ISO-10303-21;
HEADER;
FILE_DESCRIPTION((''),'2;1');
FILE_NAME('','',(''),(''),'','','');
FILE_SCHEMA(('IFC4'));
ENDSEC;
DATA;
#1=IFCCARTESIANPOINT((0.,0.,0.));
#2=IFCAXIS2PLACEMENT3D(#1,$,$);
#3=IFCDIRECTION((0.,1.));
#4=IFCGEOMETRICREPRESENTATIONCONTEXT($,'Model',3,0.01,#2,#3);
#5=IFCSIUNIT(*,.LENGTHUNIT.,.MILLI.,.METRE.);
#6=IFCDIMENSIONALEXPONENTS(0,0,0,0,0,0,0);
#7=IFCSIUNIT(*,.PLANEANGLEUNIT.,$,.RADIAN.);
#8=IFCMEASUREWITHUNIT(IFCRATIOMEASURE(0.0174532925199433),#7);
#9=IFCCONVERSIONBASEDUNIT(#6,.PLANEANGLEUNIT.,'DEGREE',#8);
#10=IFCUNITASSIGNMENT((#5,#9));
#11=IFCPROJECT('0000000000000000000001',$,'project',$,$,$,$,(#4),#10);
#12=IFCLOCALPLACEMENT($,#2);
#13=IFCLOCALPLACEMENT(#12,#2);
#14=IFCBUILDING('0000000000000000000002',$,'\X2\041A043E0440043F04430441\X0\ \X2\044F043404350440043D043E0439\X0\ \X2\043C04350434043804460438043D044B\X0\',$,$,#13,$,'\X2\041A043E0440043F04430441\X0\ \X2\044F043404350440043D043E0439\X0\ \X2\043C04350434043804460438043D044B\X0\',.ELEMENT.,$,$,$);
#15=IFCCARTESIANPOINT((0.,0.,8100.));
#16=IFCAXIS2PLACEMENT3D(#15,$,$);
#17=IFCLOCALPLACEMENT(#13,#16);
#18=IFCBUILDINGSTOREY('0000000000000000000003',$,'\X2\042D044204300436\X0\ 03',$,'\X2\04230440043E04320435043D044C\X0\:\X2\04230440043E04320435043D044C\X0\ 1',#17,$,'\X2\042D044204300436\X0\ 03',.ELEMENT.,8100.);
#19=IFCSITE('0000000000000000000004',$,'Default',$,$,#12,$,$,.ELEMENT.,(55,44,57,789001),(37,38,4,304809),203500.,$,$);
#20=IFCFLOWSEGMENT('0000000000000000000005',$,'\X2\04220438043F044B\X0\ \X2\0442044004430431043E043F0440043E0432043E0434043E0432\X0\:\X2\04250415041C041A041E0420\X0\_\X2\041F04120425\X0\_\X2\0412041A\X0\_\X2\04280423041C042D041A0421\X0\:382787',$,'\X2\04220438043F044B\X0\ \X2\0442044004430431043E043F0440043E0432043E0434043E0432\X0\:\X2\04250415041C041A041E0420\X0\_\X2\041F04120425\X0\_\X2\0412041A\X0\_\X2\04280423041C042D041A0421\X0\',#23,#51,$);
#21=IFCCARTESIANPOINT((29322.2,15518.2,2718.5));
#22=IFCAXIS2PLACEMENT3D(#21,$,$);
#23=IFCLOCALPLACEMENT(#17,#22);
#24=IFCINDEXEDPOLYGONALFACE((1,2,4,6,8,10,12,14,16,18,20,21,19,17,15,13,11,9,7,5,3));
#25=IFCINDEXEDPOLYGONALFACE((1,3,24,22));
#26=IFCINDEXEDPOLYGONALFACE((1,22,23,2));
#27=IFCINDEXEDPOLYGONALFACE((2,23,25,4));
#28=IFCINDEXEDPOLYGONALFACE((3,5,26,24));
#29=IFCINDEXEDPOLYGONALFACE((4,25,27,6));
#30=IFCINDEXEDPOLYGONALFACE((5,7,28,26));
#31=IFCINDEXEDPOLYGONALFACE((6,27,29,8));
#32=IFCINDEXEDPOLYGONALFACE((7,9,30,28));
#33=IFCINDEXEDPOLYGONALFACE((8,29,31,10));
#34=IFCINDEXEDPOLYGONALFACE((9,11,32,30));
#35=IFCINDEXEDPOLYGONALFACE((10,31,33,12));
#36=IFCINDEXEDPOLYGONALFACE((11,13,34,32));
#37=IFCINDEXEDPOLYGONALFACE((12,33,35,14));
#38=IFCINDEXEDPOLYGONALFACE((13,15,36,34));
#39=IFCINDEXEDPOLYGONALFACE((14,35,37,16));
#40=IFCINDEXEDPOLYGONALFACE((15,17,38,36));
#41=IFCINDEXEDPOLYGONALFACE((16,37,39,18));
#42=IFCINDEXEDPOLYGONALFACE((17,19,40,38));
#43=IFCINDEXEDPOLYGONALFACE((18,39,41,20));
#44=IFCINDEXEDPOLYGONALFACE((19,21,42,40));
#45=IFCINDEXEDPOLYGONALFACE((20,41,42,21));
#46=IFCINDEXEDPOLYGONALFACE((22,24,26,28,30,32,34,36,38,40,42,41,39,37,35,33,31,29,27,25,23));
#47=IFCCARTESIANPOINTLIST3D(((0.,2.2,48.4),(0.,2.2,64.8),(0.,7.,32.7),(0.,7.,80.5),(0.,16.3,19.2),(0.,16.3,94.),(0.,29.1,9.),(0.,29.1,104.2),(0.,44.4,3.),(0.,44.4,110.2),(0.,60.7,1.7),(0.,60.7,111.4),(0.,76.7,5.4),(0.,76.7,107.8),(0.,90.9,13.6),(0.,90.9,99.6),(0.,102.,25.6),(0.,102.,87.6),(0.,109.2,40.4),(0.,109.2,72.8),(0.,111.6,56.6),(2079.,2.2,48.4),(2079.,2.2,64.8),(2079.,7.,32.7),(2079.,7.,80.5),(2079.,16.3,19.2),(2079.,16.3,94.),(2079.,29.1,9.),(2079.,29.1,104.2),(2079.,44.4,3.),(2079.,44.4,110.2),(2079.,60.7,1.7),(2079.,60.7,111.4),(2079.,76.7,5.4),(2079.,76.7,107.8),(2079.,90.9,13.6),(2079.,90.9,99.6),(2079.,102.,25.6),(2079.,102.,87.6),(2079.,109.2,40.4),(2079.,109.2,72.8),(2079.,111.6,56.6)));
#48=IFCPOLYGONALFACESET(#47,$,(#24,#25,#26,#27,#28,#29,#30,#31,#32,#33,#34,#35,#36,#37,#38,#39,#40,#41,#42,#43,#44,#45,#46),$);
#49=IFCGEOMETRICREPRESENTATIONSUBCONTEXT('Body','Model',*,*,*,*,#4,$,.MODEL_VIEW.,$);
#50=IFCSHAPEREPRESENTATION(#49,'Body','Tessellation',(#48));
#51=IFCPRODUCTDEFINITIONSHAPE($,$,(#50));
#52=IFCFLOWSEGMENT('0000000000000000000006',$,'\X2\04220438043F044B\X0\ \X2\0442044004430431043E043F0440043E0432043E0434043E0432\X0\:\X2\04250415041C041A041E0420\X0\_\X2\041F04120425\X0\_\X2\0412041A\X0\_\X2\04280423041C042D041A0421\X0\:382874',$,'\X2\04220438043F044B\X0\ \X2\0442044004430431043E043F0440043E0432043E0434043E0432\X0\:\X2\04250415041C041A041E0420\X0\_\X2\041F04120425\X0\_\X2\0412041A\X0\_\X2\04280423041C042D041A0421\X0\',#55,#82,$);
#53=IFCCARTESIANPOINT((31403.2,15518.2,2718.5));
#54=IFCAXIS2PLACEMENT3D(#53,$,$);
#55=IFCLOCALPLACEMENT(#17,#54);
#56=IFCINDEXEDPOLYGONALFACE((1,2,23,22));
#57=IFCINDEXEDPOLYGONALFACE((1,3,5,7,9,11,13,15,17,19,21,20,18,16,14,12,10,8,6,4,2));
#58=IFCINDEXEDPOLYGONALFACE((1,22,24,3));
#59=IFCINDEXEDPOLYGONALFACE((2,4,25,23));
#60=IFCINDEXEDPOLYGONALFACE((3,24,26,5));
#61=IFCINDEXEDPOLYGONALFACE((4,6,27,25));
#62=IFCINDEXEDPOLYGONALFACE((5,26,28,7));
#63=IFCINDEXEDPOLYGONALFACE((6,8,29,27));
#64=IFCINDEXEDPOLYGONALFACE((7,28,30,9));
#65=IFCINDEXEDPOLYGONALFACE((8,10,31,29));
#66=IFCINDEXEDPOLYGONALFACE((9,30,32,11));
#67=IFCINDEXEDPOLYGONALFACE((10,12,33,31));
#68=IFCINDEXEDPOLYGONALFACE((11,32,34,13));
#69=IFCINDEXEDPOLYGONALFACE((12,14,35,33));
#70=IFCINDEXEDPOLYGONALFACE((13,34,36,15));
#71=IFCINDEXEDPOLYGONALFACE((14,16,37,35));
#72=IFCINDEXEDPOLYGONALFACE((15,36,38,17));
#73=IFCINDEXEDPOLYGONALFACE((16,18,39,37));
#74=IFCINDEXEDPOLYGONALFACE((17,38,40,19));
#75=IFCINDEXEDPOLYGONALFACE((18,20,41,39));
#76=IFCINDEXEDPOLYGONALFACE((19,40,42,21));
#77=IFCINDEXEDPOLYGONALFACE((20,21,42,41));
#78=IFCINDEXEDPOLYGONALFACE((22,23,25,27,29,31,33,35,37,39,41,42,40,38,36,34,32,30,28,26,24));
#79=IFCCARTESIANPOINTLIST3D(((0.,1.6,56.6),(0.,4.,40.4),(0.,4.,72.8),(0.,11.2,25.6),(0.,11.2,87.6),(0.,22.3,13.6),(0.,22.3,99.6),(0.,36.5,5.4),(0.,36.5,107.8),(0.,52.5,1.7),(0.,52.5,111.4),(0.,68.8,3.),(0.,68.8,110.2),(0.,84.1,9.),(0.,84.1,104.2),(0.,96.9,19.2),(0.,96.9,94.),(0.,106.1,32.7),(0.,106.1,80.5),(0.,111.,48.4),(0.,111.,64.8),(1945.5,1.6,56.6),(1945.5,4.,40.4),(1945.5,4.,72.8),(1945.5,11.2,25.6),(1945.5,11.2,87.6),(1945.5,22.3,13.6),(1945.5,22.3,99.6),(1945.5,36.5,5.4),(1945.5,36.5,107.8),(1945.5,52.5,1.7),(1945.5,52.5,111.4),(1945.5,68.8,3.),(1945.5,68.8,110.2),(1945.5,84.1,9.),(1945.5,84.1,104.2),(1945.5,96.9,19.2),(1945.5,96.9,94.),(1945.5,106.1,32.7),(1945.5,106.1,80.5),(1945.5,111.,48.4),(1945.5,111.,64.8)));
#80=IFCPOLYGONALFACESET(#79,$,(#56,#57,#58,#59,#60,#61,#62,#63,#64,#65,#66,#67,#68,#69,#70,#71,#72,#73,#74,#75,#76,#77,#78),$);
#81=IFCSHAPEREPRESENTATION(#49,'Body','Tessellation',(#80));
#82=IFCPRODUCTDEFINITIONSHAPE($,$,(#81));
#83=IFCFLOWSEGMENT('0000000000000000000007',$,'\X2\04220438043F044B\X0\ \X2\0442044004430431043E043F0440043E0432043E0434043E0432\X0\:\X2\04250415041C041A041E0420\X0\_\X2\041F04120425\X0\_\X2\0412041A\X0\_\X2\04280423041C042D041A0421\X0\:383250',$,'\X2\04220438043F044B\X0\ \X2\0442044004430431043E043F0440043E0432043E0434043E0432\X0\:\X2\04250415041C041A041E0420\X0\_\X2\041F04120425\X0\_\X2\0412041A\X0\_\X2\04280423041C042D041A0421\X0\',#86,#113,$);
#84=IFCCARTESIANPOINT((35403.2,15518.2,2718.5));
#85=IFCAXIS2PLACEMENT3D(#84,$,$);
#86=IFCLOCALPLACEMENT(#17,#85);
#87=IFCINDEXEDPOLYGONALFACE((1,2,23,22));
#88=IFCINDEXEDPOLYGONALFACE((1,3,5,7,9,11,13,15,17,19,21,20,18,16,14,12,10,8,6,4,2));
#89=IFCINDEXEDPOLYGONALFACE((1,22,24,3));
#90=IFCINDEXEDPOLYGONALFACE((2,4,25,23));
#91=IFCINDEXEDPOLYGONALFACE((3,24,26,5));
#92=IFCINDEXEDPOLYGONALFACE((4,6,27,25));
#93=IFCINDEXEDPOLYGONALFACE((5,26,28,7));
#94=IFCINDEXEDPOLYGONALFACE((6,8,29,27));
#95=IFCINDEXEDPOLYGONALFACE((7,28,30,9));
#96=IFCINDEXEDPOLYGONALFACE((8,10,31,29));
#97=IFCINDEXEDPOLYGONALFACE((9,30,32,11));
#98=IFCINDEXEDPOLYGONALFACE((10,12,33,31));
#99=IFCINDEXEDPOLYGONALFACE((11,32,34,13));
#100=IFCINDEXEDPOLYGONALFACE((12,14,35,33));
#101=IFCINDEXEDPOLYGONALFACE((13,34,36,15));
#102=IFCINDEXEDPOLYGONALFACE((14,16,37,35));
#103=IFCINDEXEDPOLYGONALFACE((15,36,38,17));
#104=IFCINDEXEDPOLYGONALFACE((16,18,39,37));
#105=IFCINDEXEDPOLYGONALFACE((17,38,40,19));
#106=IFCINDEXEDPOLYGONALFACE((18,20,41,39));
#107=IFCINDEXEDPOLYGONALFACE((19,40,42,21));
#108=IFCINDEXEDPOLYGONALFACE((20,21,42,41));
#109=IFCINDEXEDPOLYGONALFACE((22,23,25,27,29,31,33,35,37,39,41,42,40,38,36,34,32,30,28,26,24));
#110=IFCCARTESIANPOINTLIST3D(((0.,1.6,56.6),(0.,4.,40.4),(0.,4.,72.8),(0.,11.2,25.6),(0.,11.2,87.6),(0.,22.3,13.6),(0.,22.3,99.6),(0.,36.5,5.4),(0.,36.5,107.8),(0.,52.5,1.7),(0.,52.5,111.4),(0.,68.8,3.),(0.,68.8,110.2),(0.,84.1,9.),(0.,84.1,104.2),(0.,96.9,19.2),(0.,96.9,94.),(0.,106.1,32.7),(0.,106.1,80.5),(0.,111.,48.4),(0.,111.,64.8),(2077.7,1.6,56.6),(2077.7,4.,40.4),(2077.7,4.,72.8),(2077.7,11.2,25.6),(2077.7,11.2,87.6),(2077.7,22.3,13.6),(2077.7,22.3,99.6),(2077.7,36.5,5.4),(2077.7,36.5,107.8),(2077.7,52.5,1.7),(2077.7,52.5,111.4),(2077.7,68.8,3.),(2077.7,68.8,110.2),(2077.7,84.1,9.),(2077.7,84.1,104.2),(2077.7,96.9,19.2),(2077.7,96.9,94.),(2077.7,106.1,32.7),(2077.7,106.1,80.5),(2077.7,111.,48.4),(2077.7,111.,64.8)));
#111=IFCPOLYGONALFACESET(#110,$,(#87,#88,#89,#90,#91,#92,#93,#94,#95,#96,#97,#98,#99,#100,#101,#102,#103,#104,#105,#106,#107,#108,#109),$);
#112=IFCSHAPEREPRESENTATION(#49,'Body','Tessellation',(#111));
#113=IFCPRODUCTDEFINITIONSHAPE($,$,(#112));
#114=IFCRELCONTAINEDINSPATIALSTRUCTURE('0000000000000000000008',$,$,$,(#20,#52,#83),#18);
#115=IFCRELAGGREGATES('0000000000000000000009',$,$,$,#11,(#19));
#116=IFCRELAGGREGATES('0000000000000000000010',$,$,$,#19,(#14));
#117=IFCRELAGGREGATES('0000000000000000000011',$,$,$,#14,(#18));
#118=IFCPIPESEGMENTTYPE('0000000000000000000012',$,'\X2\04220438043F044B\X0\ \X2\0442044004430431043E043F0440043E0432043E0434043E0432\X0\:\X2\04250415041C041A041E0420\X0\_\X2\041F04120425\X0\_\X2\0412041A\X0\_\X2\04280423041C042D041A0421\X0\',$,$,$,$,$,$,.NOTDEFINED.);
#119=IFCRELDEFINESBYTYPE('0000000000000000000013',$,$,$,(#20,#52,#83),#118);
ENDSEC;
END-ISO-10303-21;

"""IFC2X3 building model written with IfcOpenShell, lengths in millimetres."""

from ifc_helpers import new_model, entity, si_unit, converted_unit, direction, frame, frame_2d, origin, origin_2d_with_axis, place, context, subcontext, project, spatial, circle, extrude, type_object, element, save


model = new_model("IFC2X3")

# Units and contexts
model_context = context("Model", 3, precision=0.01, world=origin(), true_north=direction((0.0, 1.0)))
body_context = subcontext(model_context, "Body", "Model", "MODEL_VIEW")
ifc_project = project(units=[si_unit("LENGTHUNIT", "METRE", prefix="MILLI"), converted_unit("PLANEANGLEUNIT", "DEGREE", entity("IfcRatioMeasure", 0.0174532925199433), si_unit("PLANEANGLEUNIT", "RADIAN"), dimensions=[0, 0, 0, 0, 0, 0, 0])], contexts=[model_context])

# Site, building, storey
site_placement = place(None, frame((0.0, 0.0, 0.0)))
site = spatial("IfcSite", under=ifc_project, at=site_placement, Name="Default", CompositionType="ELEMENT", RefLatitude=(55, 44, 57, 789001), RefLongitude=(37, 38, 4, 304809), RefElevation=203500.0)
building_placement = place(site_placement, origin())
building = spatial("IfcBuilding", under=site, at=building_placement, Name="Корпус ядерной медицины", LongName="Корпус ядерной медицины", CompositionType="ELEMENT")
storey_placement = place(building_placement, frame((0.0, 0.0, 8100.0)))
storey = spatial("IfcBuildingStorey", under=building, at=storey_placement, Name="Этаж 03", ObjectType="Уровень:Уровень 1", LongName="Этаж 03", CompositionType="ELEMENT", Elevation=8100.0)

# Flow segments
pipe_segment_type = type_object("IfcPipeSegmentType", Name="Типы трубопроводов:ХЕМКОР_ПВХ_ВК_ШУМЭКС", PredefinedType="NOTDEFINED")
flow_segment_1_placement = place(storey_placement, frame((29322.2, 15518.2, 2718.5)))
element("IfcFlowSegment", 1, at=flow_segment_1_placement, inside=storey, type_object=pipe_segment_type, Name="Типы трубопроводов:ХЕМКОР_ПВХ_ВК_ШУМЭКС:382787", ObjectType="Типы трубопроводов:ХЕМКОР_ПВХ_ВК_ШУМЭКС", context=body_context, shape_type="SweptSolid", body=[
    extrude(circle(Radius=55.0, at=frame_2d((0.0, 0.0), x_axis=(1.0, 0.0))), frame((0.0, 56.6, 56.6), z_axis=(1.0, 0.0, 0.0), x_axis=(0.0, 1.0, 0.0)), (0.0, 0.0, 1.0), 2079.0),
])
flow_segment_2_placement = place(storey_placement, frame((31403.2, 15518.2, 2718.5)))
element("IfcFlowSegment", 2, at=flow_segment_2_placement, inside=storey, type_object=pipe_segment_type, Name="Типы трубопроводов:ХЕМКОР_ПВХ_ВК_ШУМЭКС:382874", ObjectType="Типы трубопроводов:ХЕМКОР_ПВХ_ВК_ШУМЭКС", context=body_context, shape_type="SweptSolid", body=[
    extrude(circle(Radius=55.0, at=origin_2d_with_axis()), frame((0.0, 56.6, 56.6), z_axis=(1.0, 0.0, 0.0), x_axis=(0.0, -1.0, 0.0)), (0.0, 0.0, 1.0), 1945.5),
])
flow_segment_3_placement = place(storey_placement, frame((35403.2, 15518.2, 2718.5)))
element("IfcFlowSegment", 3, at=flow_segment_3_placement, inside=storey, type_object=pipe_segment_type, Name="Типы трубопроводов:ХЕМКОР_ПВХ_ВК_ШУМЭКС:383250", ObjectType="Типы трубопроводов:ХЕМКОР_ПВХ_ВК_ШУМЭКС", context=body_context, shape_type="SweptSolid", body=[
    extrude(circle(Radius=55.0, at=origin_2d_with_axis()), frame((0.0, 56.6, 56.6), z_axis=(1.0, 0.0, 0.0), x_axis=(0.0, -1.0, 0.0)), (0.0, 0.0, 1.0), 2077.7),
])

save(model, "model.ifc")
